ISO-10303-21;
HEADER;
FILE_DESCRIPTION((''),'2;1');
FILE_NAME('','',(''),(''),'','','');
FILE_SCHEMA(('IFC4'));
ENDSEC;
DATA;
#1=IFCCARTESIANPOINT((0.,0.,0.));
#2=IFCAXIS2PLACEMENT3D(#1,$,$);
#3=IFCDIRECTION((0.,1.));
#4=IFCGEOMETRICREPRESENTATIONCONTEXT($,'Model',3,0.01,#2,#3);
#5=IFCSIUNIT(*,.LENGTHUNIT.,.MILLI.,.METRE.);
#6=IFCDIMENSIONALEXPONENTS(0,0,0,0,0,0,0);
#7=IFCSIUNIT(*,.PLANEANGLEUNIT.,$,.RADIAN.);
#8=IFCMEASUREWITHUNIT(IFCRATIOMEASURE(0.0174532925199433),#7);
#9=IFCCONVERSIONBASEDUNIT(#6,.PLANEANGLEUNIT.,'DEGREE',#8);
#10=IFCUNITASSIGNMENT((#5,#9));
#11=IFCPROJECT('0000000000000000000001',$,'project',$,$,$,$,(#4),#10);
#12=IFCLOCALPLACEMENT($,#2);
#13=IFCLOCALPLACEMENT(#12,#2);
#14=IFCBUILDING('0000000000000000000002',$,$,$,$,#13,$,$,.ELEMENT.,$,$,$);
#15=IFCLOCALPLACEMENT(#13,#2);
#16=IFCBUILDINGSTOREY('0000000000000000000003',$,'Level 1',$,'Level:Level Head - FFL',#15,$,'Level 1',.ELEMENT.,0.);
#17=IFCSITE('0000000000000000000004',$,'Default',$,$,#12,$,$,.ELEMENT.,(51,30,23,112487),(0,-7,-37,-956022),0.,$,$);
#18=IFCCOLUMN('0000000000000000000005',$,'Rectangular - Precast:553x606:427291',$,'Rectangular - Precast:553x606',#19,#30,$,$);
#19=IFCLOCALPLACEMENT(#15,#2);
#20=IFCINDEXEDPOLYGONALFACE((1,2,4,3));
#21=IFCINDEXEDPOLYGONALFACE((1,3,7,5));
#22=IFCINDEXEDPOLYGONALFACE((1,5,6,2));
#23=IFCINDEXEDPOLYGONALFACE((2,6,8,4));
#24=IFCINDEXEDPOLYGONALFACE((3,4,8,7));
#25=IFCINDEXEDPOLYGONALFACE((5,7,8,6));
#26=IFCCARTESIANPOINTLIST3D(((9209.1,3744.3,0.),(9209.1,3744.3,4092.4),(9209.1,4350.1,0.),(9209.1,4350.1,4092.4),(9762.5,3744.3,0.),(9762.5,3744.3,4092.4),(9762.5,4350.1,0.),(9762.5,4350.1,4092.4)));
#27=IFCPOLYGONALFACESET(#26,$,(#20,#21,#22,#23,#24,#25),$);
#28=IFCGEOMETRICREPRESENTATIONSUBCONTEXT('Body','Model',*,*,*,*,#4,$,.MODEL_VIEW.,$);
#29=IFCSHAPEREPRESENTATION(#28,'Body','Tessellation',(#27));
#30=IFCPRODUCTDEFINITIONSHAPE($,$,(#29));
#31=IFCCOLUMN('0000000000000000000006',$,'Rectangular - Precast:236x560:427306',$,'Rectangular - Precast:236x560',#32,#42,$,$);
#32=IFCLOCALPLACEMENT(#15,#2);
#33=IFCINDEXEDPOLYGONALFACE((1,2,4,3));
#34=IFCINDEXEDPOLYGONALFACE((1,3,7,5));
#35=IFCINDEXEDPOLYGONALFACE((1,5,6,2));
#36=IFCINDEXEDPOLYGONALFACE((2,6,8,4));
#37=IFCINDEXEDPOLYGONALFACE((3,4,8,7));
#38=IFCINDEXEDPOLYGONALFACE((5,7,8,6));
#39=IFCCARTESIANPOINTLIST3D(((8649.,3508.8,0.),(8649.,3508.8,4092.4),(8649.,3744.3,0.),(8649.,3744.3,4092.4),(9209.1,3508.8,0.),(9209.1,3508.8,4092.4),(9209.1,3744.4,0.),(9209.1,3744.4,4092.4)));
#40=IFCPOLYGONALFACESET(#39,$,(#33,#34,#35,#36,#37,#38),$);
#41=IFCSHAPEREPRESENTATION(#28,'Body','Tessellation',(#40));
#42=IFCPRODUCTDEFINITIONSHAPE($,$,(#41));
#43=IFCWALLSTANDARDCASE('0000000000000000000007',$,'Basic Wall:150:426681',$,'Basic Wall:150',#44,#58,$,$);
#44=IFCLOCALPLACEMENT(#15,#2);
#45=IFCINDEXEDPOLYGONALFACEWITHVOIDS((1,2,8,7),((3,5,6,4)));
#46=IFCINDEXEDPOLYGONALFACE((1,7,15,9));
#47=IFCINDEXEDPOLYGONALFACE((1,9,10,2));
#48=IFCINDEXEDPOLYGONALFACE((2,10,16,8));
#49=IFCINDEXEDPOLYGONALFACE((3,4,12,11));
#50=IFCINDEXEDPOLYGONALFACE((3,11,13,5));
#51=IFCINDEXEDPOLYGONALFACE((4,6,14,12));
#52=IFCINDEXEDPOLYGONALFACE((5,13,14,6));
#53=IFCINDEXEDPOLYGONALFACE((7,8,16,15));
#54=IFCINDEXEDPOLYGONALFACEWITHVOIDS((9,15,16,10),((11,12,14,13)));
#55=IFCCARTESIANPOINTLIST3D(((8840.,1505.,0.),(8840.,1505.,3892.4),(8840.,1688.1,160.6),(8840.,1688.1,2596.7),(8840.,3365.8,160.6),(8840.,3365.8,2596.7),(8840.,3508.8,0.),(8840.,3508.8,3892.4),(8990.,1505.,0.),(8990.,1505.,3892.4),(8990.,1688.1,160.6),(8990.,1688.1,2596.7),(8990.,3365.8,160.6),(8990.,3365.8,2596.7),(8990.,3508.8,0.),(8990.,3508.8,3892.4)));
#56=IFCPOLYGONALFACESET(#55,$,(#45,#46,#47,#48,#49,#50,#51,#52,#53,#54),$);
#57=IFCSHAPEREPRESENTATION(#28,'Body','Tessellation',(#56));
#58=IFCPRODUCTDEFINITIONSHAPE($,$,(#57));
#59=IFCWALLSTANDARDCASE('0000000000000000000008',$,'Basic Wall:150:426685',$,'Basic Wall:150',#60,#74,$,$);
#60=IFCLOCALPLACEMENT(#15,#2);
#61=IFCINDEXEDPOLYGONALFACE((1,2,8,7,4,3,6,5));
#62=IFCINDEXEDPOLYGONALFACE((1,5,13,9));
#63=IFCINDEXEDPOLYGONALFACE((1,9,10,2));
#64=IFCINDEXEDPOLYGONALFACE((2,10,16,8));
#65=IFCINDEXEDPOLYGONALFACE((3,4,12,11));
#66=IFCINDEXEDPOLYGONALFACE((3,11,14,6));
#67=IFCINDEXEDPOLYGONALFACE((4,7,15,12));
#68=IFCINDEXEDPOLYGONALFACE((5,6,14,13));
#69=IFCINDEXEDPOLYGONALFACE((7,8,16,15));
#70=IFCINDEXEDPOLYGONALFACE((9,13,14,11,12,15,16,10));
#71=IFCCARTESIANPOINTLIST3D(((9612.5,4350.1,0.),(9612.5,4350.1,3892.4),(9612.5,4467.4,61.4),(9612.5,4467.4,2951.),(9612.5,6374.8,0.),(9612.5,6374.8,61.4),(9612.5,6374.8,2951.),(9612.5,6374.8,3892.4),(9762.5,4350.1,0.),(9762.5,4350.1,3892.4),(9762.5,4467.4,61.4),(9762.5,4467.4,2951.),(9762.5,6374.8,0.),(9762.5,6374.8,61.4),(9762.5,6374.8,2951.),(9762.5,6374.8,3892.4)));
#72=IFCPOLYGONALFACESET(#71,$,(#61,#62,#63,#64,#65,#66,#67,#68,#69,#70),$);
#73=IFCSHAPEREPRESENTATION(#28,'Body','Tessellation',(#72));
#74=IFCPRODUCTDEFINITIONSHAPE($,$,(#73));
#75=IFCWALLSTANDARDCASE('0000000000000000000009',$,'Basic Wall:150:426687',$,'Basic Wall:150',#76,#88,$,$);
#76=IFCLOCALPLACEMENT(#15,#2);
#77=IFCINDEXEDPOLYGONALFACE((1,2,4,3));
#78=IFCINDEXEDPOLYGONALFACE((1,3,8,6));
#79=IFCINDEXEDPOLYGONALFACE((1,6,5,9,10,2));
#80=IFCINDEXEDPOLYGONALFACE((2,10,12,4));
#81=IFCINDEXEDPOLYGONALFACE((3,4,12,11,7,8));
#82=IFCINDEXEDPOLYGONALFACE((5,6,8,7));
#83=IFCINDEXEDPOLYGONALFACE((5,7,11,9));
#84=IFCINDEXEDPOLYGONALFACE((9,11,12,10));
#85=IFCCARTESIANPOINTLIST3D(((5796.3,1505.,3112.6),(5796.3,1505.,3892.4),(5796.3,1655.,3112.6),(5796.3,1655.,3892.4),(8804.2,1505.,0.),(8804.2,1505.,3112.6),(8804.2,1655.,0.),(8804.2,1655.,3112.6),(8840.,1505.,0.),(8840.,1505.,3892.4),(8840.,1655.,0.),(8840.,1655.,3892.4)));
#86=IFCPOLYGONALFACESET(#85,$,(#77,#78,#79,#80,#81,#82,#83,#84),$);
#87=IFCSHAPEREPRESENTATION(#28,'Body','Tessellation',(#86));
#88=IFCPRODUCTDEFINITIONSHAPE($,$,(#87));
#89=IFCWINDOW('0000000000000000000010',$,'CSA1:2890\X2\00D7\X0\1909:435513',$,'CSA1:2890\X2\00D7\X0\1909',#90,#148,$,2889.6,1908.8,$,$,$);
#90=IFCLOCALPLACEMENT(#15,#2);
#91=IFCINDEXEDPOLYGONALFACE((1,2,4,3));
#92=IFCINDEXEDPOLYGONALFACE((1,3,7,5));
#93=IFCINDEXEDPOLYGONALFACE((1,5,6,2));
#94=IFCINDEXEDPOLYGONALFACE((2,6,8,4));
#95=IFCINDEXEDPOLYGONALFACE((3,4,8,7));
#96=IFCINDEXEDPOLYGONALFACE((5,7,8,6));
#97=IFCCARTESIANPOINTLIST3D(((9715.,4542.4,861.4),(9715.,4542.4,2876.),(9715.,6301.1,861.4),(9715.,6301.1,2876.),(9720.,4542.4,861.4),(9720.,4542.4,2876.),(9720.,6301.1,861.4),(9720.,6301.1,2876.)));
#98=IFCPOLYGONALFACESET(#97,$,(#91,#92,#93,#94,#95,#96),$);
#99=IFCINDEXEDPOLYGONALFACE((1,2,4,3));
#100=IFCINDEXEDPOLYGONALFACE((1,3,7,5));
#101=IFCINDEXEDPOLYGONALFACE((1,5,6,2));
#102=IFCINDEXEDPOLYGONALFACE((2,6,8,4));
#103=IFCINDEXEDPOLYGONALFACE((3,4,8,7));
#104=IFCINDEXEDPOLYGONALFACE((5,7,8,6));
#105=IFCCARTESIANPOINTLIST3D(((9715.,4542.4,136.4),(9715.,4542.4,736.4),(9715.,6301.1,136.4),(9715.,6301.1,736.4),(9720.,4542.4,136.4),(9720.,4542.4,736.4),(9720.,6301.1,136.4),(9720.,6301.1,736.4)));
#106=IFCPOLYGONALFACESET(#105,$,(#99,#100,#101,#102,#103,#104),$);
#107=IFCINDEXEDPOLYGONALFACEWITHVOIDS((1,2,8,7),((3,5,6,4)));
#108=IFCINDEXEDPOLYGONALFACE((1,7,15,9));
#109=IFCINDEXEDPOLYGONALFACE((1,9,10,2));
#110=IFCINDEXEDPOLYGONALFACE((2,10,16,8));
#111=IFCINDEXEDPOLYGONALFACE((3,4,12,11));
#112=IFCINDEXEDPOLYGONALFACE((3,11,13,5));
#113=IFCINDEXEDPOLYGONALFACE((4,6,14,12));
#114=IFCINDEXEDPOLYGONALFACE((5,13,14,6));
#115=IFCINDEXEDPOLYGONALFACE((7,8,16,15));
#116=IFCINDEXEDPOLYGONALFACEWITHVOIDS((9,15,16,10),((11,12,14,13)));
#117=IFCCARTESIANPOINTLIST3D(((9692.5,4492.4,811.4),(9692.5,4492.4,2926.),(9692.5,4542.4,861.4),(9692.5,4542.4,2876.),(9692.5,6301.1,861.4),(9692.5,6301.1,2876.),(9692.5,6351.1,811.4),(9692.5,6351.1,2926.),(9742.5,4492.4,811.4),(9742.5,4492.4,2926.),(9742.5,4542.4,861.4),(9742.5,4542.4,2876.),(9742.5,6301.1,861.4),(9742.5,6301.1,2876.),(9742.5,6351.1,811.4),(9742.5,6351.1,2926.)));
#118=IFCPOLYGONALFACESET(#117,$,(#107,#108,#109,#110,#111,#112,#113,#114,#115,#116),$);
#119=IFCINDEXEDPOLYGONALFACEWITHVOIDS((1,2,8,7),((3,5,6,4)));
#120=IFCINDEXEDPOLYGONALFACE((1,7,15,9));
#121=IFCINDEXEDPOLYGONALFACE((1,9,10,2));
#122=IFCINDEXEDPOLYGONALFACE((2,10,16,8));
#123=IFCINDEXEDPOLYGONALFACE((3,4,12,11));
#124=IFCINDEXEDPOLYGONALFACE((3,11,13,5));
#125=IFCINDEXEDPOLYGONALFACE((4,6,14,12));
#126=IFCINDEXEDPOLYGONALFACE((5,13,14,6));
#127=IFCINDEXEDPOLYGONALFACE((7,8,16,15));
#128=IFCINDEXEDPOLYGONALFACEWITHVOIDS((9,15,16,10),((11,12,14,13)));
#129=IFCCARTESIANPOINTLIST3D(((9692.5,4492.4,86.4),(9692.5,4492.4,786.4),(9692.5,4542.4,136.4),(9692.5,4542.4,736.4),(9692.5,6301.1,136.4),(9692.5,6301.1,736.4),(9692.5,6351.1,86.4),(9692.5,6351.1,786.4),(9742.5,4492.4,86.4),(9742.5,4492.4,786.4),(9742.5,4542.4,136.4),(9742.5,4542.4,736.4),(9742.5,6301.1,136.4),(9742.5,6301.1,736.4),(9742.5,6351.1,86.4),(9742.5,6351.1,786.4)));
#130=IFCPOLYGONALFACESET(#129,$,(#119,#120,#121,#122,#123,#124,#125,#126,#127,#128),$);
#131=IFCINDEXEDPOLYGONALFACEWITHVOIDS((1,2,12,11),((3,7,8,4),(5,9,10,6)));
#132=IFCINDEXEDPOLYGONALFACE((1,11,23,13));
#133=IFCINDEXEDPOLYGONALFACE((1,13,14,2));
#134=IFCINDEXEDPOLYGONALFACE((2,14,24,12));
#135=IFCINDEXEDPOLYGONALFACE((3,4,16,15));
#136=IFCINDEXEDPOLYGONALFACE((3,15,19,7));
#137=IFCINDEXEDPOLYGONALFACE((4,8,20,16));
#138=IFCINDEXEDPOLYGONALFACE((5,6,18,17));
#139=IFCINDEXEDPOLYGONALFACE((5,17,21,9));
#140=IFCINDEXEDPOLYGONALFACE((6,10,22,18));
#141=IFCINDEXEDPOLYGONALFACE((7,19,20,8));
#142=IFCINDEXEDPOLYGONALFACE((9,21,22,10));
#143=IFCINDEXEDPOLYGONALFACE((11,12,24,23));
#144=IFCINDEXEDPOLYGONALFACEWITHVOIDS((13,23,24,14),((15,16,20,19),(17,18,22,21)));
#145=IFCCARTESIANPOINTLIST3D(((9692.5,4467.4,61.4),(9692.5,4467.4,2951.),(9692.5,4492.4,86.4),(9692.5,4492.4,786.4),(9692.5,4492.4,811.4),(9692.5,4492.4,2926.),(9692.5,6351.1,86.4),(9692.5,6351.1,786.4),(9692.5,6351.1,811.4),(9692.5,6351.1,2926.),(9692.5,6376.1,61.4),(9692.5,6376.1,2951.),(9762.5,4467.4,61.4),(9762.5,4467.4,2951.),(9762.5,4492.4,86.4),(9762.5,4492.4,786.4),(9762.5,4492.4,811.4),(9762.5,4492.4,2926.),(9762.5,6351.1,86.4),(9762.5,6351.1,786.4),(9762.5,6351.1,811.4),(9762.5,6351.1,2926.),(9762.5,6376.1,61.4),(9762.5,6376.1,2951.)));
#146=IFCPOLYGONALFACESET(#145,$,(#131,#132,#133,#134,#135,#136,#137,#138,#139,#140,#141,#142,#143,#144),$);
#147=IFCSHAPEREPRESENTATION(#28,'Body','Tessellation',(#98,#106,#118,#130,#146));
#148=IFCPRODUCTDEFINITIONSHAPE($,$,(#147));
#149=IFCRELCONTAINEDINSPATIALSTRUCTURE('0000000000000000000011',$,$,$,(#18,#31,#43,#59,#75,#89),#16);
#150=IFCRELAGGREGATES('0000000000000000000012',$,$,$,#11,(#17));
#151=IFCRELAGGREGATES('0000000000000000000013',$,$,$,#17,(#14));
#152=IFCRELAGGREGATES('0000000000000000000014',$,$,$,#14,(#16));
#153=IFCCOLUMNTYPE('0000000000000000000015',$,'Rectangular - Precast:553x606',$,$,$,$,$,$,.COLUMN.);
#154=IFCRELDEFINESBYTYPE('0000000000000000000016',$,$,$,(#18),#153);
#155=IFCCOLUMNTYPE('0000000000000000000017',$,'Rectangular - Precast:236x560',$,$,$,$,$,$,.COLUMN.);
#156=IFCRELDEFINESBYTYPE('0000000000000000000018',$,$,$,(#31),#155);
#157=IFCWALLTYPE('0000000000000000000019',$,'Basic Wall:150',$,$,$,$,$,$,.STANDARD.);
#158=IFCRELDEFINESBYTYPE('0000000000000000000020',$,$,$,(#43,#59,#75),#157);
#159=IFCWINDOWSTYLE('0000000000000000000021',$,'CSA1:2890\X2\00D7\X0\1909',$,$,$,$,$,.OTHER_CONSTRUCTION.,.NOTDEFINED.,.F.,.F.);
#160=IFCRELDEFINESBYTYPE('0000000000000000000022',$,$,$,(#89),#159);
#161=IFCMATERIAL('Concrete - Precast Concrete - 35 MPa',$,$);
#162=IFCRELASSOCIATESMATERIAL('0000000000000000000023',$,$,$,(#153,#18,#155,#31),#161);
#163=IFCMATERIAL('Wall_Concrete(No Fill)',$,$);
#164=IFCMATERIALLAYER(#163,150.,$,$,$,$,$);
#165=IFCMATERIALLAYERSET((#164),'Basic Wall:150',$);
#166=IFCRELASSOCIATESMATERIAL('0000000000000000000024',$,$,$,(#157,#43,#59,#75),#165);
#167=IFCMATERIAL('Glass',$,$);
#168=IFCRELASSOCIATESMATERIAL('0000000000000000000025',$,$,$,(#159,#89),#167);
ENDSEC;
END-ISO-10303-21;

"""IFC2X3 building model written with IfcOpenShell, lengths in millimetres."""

from ifc_helpers import new_model, entity, si_unit, converted_unit, direction, frame, frame_2d, origin, origin_2d_with_axis, place, context, subcontext, project, spatial, polyline, rectangle, outline, extrude, source, transform, mapped, material, layer, layer_set, layer_usage, type_object, type_shapes, element, save


model = new_model("IFC2X3")

# Units and contexts
model_context = context("Model", 3, precision=0.01, world=origin(), true_north=direction((0.0, 1.0)))
body_context = subcontext(model_context, "Body", "Model", "MODEL_VIEW")
ifc_project = project(units=[si_unit("LENGTHUNIT", "METRE", prefix="MILLI"), converted_unit("PLANEANGLEUNIT", "DEGREE", entity("IfcRatioMeasure", 0.0174532925199433), si_unit("PLANEANGLEUNIT", "RADIAN"), dimensions=[0, 0, 0, 0, 0, 0, 0])], contexts=[model_context])

# Site, building, storey
site_placement = place(None, origin())
site = spatial("IfcSite", under=ifc_project, at=site_placement, Name="Default", CompositionType="ELEMENT", RefLatitude=(51, 30, 23, 112487), RefLongitude=(0, -7, -37, -956022), RefElevation=0.0)
building_placement = place(site_placement, origin())
building = spatial("IfcBuilding", under=site, at=building_placement, CompositionType="ELEMENT")
storey_placement = place(building_placement, origin())
storey = spatial("IfcBuildingStorey", under=building, at=storey_placement, Name="Level 1", ObjectType="Level:Level Head - FFL", LongName="Level 1", CompositionType="ELEMENT", Elevation=0.0)

# Columns
ifc_material_1 = material(Name="Concrete - Precast Concrete - 35 MPa")
column_type_1 = type_object("IfcColumnType", Name="Rectangular - Precast:553x606", PredefinedType="COLUMN", material=ifc_material_1)
shared_shape_1 = source(origin(), body_context, "Body", "SweptSolid", [
    extrude(rectangle(XDim=605.8, YDim=553.4, at=frame_2d((0.0, 0.0), x_axis=(1.0, 0.0))), frame((0.0, 0.0, 0.0), z_axis=(0.0, 0.0, 1.0), x_axis=(0.0, -1.0, 0.0)), (0.0, 0.0, 1.0), 4092.4),
])
type_shapes(column_type_1, [shared_shape_1])
column_1_placement = place(storey_placement, frame((9485.8, 4047.2, 0.0)))
element("IfcColumn", 1, at=column_1_placement, inside=storey, type_object=column_type_1, material=ifc_material_1, Name="Rectangular - Precast:553x606:427291", ObjectType="Rectangular - Precast:553x606", context=body_context, shape_type="MappedRepresentation", body=[
    mapped(shared_shape_1, transform((0.0, 0.0, 0.0), scale=1.0)),
])
column_type_2 = type_object("IfcColumnType", Name="Rectangular - Precast:236x560", PredefinedType="COLUMN", material=ifc_material_1)
shared_shape_2 = source(origin(), body_context, "Body", "SweptSolid", [
    extrude(rectangle(XDim=560.1, YDim=235.6, at=frame_2d((0.0, 0.0), x_axis=(1.0, 0.0))), frame((0.0, 0.0, 0.0), z_axis=(0.0, 0.0, 1.0), x_axis=(0.0, -1.0, 0.0)), (0.0, 0.0, 1.0), 4092.4),
])
type_shapes(column_type_2, [shared_shape_2])
column_2_placement = place(storey_placement, frame((8929.0, 3626.6, 0.0), z_axis=(0.0, 0.0, 1.0), x_axis=(-0.000004, 1.0, 0.0)))
element("IfcColumn", 2, at=column_2_placement, inside=storey, type_object=column_type_2, material=ifc_material_1, Name="Rectangular - Precast:236x560:427306", ObjectType="Rectangular - Precast:236x560", context=body_context, shape_type="MappedRepresentation", body=[
    mapped(shared_shape_2, transform((0.0, 0.0, 0.0), scale=1.0)),
])

# Walls, openings
ifc_material_2 = material(Name="Wall_Concrete(No Fill)")
ifc_layer = layer(ifc_material_2, 150.0)
ifc_layer_set = layer_set([ifc_layer], Name="Basic Wall:150")
ifc_layer_usage_1 = layer_usage(ifc_layer_set, "AXIS2", "NEGATIVE", 75.0)
wall_type = type_object("IfcWallType", Name="Basic Wall:150", PredefinedType="STANDARD", material=ifc_layer_set)
wall_1_placement = place(storey_placement, frame((8915.0, 1505.0, 0.0), z_axis=(0.0, 0.0, 1.0), x_axis=(0.0, 1.0, 0.0)))
wall_1 = element("IfcWallStandardCase", 3, at=wall_1_placement, inside=storey, type_object=wall_type, material=ifc_layer_usage_1, Name="Basic Wall:150:426681", ObjectType="Basic Wall:150", context=body_context, shape_type="SweptSolid", body=[
    extrude(rectangle(XDim=2003.7, YDim=150.0, at=frame_2d((1001.9, 0.0), x_axis=(-1.0, 0.0))), origin(), (0.0, 0.0, 1.0), 3892.4),
])
opening_1_placement = place(wall_1_placement, origin())
element("IfcOpeningElement", 4, at=opening_1_placement, cuts=wall_1, ObjectType="Opening", context=body_context, shape_type="SweptSolid", body=[
    extrude(rectangle(XDim=2436.1, YDim=1677.7, at=frame_2d((0.0, 0.0), x_axis=(1.0, 0.0))), frame((1021.9, -75.0, 1378.6), z_axis=(0.0, 1.0, 0.0), x_axis=(0.0, 0.0, -1.0)), (0.0, 0.0, 1.0), 150.0),
])
ifc_layer_usage_2 = layer_usage(ifc_layer_set, "AXIS2", "NEGATIVE", 75.0)
wall_2_placement = place(storey_placement, frame((9687.5, 4350.1, 0.0), z_axis=(0.0, 0.0, 1.0), x_axis=(0.0, 1.0, 0.0)))
wall_2 = element("IfcWallStandardCase", 5, at=wall_2_placement, inside=storey, type_object=wall_type, material=ifc_layer_usage_2, Name="Basic Wall:150:426685", ObjectType="Basic Wall:150", context=body_context, shape_type="SweptSolid", body=[
    extrude(rectangle(XDim=2024.7, YDim=150.0, at=frame_2d((1012.4, 0.0), x_axis=(-1.0, 0.0))), origin(), (0.0, 0.0, 1.0), 3892.4),
])
opening_2_placement = place(wall_2_placement, origin())
element("IfcOpeningElement", 6, at=opening_2_placement, cuts=wall_2, ObjectType="Opening", context=body_context, shape_type="SweptSolid", body=[
    extrude(rectangle(XDim=2889.6, YDim=1908.8, at=origin_2d_with_axis()), frame((1071.6, -75.0, 1506.2), z_axis=(0.0, 1.0, 0.0), x_axis=(0.0, 0.0, -1.0)), (0.0, 0.0, 1.0), 150.0),
])
ifc_layer_usage_3 = layer_usage(ifc_layer_set, "AXIS2", "NEGATIVE", 75.0)
wall_3_placement = place(storey_placement, frame((5796.3, 1580.0, 0.0)))
wall_3 = element("IfcWallStandardCase", 7, at=wall_3_placement, inside=storey, type_object=wall_type, material=ifc_layer_usage_3, Name="Basic Wall:150:426687", ObjectType="Basic Wall:150", context=body_context, shape_type="SweptSolid", body=[
    extrude(rectangle(XDim=3043.8, YDim=150.0, at=frame_2d((1521.9, 0.0), x_axis=(-1.0, 0.0))), origin(), (0.0, 0.0, 1.0), 3892.4),
])
opening_3_placement = place(wall_3_placement, origin())
element("IfcOpeningElement", 8, at=opening_3_placement, cuts=wall_3, ObjectType="Opening", context=body_context, shape_type="SweptSolid", body=[
    extrude(rectangle(XDim=3112.6, YDim=3008.0, at=origin_2d_with_axis()), frame((1504.0, -75.0, 1556.3), z_axis=(0.0, 1.0, 0.0), x_axis=(0.0, 0.0, -1.0)), (0.0, 0.0, 1.0), 150.0),
])

# Window
ifc_material_3 = material(Name="Glass")
window_style_1 = type_object("IfcWindowStyle", Name="CSA1:2890×1909", ConstructionType="OTHER_CONSTRUCTION", OperationType="NOTDEFINED", ParameterTakesPrecedence=False, Sizeable=False, material=ifc_material_3)
shared_shape_3 = source(origin(), body_context, "Body", "SweptSolid", [
    extrude(rectangle(XDim=5.0, YDim=1758.8, at=origin_2d_with_axis()), frame((954.4, 45.0, 800.0), z_axis=(0.0, 0.0, 1.0), x_axis=(0.0, 1.0, 0.0)), (0.0, 0.0, 1.0), 2014.6),
    extrude(rectangle(XDim=5.0, YDim=1758.8, at=origin_2d_with_axis()), frame((954.4, 45.0, 75.0), z_axis=(0.0, 0.0, 1.0), x_axis=(0.0, 1.0, 0.0)), (0.0, 0.0, 1.0), 600.0),
    extrude(outline(polyline([(-929.4, -1057.3), (929.4, -1057.3), (929.4, 1057.3), (-929.4, 1057.3), (-929.4, -1057.3)]), holes=[polyline([(-879.4, -1007.3), (-879.4, 1007.3), (879.4, 1007.3), (879.4, -1007.3), (-879.4, -1007.3)])]), frame((954.4, 20.0, 1807.3), z_axis=(0.0, 1.0, 0.0), x_axis=(1.0, 0.0, 0.0)), (0.0, 0.0, 1.0), 50.0),
    extrude(outline(polyline([(-929.4, -350.0), (929.4, -350.0), (929.4, 350.0), (-929.4, 350.0), (-929.4, -350.0)]), holes=[polyline([(-879.4, -300.0), (-879.4, 300.0), (879.4, 300.0), (879.4, -300.0), (-879.4, -300.0)])]), frame((954.4, 20.0, 375.0), z_axis=(0.0, 1.0, 0.0), x_axis=(1.0, 0.0, 0.0)), (0.0, 0.0, 1.0), 50.0),
    extrude(outline(polyline([(-954.4, -1444.8), (954.4, -1444.8), (954.4, 1444.8), (-954.4, 1444.8), (-954.4, -1444.8)]), holes=[polyline([(-929.4, -1419.8), (-929.4, 694.8), (929.4, 694.8), (929.4, -1419.8), (-929.4, -1419.8)]), polyline([(-929.4, 719.8), (-929.4, 1419.8), (929.4, 1419.8), (929.4, 719.8), (-929.4, 719.8)])]), frame((954.4, 0.0, 1444.8), z_axis=(0.0, 1.0, 0.0), x_axis=(1.0, 0.0, 0.0)), (0.0, 0.0, 1.0), 70.0),
])
type_shapes(window_style_1, [shared_shape_3])
window_1_placement = place(storey_placement, frame((9762.5, 4467.4, 61.4), z_axis=(0.0, 0.0, 1.0), x_axis=(0.0, 1.0, 0.0)))
element("IfcWindow", 9, at=window_1_placement, inside=storey, type_object=window_style_1, material=ifc_material_3, Name="CSA1:2890×1909:435513", ObjectType="CSA1:2890×1909", OverallHeight=2889.6, OverallWidth=1908.8, context=body_context, shape_type="MappedRepresentation", body=[
    mapped(shared_shape_3, transform((0.0, 0.0, 0.0), scale=1.0)),
])

save(model, "model.ifc")
